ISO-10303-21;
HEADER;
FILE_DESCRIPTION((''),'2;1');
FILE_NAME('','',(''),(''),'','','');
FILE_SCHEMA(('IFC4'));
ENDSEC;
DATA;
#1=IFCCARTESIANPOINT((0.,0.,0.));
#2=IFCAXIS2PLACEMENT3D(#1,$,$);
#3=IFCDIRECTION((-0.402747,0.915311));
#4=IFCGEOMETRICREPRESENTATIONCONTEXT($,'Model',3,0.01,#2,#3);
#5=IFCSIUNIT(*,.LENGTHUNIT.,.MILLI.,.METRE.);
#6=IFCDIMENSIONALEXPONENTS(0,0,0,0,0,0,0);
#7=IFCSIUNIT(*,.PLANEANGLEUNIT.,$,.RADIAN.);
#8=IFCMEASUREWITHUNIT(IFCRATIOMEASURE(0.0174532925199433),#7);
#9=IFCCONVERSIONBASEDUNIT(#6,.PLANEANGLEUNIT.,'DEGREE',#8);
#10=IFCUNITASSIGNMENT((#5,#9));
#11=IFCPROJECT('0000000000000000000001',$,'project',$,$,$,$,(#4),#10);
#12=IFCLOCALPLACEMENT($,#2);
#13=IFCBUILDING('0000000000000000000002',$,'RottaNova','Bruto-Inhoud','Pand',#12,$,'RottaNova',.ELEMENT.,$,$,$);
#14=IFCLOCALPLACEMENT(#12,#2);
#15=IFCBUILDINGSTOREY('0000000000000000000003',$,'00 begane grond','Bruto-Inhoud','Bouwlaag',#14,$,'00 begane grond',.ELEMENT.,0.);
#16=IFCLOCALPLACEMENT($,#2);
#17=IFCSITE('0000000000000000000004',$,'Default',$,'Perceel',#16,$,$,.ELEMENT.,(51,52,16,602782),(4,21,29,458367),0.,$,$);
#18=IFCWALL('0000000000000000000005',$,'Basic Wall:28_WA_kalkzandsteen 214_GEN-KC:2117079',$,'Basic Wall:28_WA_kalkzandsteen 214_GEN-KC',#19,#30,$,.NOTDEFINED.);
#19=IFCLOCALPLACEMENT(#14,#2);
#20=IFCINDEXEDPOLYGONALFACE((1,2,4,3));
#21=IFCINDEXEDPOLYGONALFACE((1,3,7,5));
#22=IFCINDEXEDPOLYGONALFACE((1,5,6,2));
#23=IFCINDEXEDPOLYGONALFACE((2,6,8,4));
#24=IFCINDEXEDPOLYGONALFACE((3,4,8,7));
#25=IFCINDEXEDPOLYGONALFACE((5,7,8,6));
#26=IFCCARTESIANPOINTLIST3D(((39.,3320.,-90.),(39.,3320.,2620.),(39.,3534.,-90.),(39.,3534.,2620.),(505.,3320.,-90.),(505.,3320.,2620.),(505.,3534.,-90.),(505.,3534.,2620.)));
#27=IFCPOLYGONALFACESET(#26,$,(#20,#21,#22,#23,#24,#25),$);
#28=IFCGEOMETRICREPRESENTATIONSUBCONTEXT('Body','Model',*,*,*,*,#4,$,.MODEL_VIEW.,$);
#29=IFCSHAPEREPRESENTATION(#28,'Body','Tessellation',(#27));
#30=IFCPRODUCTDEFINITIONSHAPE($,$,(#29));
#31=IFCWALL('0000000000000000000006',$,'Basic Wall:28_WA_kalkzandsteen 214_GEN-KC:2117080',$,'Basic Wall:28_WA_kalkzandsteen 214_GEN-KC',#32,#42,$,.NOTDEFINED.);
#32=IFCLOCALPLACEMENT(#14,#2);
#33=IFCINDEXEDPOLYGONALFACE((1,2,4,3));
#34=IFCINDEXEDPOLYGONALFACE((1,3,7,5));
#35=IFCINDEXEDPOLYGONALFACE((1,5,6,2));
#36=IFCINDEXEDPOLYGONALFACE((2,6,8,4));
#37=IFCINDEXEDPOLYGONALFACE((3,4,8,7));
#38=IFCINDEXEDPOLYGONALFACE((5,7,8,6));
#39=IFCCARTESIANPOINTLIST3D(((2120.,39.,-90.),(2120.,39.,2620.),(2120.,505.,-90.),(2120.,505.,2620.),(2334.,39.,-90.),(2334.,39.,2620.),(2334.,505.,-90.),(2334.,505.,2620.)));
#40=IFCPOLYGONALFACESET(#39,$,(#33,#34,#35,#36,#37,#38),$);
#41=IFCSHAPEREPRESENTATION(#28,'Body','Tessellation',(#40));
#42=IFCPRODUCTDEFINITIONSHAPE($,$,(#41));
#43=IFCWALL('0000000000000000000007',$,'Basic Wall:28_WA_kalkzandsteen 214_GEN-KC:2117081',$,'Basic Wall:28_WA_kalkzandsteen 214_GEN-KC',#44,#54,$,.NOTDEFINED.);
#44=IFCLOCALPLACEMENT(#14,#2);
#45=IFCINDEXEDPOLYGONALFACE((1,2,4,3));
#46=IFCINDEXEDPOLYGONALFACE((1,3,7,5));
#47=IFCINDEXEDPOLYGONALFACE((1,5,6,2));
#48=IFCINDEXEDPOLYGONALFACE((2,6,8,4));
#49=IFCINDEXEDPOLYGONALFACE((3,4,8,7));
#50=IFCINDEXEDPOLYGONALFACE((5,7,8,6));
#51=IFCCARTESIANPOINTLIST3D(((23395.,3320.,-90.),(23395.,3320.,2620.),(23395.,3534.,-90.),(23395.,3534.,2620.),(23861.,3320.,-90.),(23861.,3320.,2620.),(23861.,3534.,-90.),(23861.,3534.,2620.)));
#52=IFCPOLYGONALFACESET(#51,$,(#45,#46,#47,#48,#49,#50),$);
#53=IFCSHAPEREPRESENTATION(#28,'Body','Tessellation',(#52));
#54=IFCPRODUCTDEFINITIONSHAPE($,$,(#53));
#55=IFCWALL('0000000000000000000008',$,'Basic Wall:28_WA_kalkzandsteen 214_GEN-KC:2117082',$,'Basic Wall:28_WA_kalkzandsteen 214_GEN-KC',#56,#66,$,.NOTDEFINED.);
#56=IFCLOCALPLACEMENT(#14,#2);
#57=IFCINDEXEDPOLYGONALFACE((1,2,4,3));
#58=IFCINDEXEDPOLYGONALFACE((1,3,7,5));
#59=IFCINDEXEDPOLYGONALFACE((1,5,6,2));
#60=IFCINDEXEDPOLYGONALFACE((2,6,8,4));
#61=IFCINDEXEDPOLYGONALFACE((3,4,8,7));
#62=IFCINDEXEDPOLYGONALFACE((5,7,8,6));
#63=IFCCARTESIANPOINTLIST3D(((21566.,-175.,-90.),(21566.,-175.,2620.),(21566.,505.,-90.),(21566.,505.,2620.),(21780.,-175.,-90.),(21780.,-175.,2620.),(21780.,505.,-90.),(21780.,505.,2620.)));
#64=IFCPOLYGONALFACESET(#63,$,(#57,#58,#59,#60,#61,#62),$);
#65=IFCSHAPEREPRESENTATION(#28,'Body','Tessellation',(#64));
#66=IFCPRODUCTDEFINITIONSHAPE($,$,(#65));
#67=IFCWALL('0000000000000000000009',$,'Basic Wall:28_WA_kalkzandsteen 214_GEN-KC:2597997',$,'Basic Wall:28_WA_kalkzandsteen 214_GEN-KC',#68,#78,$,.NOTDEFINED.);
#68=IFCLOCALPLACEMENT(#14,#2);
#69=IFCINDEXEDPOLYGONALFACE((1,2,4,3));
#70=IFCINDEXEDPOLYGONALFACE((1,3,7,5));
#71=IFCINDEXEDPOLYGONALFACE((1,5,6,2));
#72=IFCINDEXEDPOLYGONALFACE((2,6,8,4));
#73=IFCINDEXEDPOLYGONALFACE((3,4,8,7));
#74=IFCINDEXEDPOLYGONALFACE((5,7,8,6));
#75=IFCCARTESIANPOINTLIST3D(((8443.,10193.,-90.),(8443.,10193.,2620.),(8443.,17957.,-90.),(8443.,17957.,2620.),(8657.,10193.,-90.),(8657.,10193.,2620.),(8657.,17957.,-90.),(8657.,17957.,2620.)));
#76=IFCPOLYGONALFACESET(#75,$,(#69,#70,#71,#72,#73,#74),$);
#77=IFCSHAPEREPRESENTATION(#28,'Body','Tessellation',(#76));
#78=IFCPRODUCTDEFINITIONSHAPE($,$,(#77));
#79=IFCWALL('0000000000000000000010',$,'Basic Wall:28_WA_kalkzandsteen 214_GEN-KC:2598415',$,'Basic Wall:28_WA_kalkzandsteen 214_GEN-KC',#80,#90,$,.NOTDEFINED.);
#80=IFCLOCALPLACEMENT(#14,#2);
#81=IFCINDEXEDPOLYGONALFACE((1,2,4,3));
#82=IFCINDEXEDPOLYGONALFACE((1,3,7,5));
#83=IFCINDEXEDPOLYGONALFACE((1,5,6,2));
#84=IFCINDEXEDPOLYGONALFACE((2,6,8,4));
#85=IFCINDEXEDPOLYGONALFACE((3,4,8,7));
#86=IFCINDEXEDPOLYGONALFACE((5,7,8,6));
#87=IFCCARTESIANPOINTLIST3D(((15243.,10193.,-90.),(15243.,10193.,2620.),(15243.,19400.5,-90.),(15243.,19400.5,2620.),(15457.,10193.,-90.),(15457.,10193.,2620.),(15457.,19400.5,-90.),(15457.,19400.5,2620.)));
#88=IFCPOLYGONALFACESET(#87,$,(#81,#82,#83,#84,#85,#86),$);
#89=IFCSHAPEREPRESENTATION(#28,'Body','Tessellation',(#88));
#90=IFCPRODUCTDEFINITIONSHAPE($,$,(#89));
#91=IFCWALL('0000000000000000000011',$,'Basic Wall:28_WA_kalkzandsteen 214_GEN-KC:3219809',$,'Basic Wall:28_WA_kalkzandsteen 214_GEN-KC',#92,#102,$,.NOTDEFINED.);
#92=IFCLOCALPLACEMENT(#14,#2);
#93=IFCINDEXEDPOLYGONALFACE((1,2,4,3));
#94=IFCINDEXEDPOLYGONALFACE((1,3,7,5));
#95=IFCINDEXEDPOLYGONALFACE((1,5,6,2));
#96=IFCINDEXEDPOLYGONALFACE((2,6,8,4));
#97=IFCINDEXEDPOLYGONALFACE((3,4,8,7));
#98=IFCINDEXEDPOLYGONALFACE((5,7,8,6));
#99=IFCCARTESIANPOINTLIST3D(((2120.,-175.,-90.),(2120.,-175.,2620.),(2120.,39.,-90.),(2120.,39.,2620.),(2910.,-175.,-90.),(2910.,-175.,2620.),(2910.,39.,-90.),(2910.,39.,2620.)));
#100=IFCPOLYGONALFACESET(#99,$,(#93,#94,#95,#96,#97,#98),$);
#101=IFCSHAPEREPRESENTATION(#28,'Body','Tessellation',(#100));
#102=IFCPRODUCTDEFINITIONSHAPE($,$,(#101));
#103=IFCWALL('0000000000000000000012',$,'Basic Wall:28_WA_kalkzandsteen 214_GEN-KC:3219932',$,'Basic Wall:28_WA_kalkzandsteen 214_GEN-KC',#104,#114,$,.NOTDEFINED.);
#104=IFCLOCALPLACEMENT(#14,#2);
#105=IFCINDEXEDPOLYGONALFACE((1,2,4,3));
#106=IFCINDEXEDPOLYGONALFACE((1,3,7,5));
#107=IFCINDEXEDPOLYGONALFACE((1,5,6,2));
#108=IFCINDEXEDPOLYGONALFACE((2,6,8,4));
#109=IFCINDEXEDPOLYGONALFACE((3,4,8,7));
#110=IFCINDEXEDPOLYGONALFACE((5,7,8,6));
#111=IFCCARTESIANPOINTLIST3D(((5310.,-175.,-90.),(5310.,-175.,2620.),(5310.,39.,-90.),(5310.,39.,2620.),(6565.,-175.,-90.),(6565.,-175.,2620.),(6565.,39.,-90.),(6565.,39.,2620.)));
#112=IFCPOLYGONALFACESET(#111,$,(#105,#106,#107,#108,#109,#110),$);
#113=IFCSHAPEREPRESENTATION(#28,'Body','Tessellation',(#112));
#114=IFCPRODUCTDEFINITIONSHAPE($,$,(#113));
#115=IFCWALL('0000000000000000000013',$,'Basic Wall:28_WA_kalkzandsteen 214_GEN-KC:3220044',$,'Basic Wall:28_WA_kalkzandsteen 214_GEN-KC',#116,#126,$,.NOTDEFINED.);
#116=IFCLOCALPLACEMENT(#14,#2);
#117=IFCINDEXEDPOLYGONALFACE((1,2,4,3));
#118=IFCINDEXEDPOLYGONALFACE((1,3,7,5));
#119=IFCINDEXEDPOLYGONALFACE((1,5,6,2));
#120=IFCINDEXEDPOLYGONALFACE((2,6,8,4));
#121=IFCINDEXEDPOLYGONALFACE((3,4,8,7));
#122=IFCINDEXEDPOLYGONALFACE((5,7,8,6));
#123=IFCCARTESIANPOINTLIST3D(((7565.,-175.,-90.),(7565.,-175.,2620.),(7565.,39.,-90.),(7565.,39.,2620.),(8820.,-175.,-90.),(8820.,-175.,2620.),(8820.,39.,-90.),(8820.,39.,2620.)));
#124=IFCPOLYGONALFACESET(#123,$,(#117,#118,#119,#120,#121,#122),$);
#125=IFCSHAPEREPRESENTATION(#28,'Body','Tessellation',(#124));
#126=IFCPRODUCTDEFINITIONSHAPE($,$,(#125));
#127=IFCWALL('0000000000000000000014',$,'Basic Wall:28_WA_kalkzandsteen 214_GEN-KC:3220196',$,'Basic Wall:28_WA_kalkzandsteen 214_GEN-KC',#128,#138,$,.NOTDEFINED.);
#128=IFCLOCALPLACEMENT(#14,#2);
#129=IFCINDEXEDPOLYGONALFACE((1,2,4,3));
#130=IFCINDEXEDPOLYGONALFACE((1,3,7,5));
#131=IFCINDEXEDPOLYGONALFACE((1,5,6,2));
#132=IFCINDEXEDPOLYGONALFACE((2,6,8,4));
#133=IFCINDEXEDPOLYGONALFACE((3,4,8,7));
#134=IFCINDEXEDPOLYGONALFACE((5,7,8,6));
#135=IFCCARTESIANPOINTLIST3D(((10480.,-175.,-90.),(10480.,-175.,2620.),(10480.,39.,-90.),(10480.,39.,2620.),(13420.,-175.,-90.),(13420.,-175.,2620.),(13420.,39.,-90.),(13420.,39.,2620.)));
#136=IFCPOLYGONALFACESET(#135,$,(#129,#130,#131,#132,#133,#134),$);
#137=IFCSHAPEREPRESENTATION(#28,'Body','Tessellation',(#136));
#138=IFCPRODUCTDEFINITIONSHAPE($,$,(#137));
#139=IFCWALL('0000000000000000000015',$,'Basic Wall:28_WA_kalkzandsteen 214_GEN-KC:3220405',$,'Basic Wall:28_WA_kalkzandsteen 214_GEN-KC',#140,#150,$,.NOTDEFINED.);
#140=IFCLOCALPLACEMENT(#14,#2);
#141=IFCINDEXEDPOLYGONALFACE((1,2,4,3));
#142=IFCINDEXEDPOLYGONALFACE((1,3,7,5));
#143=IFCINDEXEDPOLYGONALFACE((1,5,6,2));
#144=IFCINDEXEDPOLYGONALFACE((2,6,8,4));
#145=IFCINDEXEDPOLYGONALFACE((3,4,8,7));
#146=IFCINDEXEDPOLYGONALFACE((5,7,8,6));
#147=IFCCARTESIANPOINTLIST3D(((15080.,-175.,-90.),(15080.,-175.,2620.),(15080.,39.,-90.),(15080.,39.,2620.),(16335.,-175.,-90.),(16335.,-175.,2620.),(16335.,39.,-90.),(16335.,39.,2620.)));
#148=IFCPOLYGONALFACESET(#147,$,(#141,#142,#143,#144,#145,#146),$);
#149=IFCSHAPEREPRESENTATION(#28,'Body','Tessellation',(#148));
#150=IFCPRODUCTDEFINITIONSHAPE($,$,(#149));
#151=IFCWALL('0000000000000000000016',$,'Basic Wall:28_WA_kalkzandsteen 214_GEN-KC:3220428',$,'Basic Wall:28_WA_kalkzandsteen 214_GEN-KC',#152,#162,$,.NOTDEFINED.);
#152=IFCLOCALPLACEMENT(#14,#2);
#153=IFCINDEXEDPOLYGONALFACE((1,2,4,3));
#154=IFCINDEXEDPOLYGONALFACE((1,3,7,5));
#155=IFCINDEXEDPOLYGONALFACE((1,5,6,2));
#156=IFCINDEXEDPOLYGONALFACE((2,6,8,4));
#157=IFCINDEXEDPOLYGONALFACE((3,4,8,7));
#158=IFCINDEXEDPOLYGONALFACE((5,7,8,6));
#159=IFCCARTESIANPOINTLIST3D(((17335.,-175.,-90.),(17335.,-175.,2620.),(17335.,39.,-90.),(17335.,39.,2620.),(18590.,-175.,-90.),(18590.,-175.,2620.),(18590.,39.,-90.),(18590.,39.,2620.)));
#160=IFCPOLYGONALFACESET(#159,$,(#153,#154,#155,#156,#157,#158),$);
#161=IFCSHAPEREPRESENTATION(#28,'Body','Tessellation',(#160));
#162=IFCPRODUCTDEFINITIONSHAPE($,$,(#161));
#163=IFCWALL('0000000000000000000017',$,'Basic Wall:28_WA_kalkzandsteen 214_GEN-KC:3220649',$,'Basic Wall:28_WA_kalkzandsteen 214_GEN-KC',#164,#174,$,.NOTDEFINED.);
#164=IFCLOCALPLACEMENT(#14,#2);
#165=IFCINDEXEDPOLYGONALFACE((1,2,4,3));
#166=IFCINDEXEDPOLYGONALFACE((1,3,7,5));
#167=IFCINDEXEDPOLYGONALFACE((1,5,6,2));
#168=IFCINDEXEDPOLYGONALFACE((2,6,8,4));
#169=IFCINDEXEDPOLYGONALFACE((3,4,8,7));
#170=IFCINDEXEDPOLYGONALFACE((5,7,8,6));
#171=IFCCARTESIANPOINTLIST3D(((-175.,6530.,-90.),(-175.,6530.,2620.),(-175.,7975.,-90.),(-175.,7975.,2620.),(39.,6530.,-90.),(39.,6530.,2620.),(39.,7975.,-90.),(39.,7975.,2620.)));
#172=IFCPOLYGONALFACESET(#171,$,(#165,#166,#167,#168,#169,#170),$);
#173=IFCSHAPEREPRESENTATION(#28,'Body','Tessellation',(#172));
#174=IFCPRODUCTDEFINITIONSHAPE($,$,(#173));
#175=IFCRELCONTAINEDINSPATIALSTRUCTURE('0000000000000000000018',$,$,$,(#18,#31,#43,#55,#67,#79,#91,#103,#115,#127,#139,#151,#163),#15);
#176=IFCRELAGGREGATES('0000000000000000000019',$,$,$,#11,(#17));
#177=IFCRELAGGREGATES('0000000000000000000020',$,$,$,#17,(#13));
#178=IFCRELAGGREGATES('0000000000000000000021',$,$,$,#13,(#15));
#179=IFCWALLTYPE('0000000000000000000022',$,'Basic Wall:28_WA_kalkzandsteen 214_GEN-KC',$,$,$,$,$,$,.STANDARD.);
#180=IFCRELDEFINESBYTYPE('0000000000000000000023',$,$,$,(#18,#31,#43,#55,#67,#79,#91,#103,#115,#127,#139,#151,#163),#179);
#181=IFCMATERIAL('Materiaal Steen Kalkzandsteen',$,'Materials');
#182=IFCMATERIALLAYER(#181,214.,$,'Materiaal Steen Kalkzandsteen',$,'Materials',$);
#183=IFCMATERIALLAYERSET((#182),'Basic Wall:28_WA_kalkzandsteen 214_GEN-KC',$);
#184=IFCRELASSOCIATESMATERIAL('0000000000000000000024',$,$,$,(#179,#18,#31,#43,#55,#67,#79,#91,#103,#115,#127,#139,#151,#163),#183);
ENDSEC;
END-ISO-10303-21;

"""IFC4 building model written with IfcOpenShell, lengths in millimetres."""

from ifc_helpers import new_model, entity, si_unit, converted_unit, direction, frame, frame_2d, origin, place, context, subcontext, project, spatial, rectangle, extrude, material, layer, layer_set, type_object, element, save


model = new_model("IFC4")

# Units and contexts
model_context = context("Model", 3, precision=0.01, world=origin(), true_north=direction((-0.402747, 0.915311)))
body_context = subcontext(model_context, "Body", "Model", "MODEL_VIEW")
ifc_project = project(units=[si_unit("LENGTHUNIT", "METRE", prefix="MILLI"), converted_unit("PLANEANGLEUNIT", "DEGREE", entity("IfcRatioMeasure", 0.0174532925199433), si_unit("PLANEANGLEUNIT", "RADIAN"), dimensions=[0, 0, 0, 0, 0, 0, 0])], contexts=[model_context])

# Site, building, storey
site_placement = place(None, origin())
site = spatial("IfcSite", under=ifc_project, at=site_placement, Name="Default", ObjectType="Perceel", CompositionType="ELEMENT", RefLatitude=(51, 52, 16, 602782), RefLongitude=(4, 21, 29, 458367), RefElevation=0.0)
building_placement = place(None, origin())
building = spatial("IfcBuilding", under=site, at=building_placement, Name="RottaNova", Description="Bruto-Inhoud", ObjectType="Pand", LongName="RottaNova", CompositionType="ELEMENT")
storey_placement = place(building_placement, origin())
storey = spatial("IfcBuildingStorey", under=building, at=storey_placement, Name="00 begane grond", Description="Bruto-Inhoud", ObjectType="Bouwlaag", LongName="00 begane grond", CompositionType="ELEMENT", Elevation=0.0)

# Walls
ifc_material_1 = material(Name="Materiaal Steen Kalkzandsteen", Category="Materials")
ifc_layer_1 = layer(ifc_material_1, 214.0, Name="Materiaal Steen Kalkzandsteen", Category="Materials")
ifc_layer_set_1 = layer_set([ifc_layer_1], Name="Basic Wall:28_WA_kalkzandsteen 214_GEN-KC")
wall_type = type_object("IfcWallType", Name="Basic Wall:28_WA_kalkzandsteen 214_GEN-KC", PredefinedType="STANDARD", material=ifc_layer_set_1)
wall_1_placement = place(storey_placement, frame((39.0, 3427.0, -90.0)))
element("IfcWall", 1, at=wall_1_placement, inside=storey, type_object=wall_type, material=ifc_layer_set_1, Name="Basic Wall:28_WA_kalkzandsteen 214_GEN-KC:2117079", ObjectType="Basic Wall:28_WA_kalkzandsteen 214_GEN-KC", PredefinedType="NOTDEFINED", context=body_context, shape_type="SweptSolid", body=[
    extrude(rectangle(XDim=466.0, YDim=214.0, at=frame_2d((233.0, 0.0), x_axis=(-1.0, 0.0))), origin(), (0.0, 0.0, 1.0), 2710.0),
])
wall_2_placement = place(storey_placement, frame((2227.0, 505.0, -90.0), z_axis=(0.0, 0.0, 1.0), x_axis=(0.0, -1.0, 0.0)))
element("IfcWall", 2, at=wall_2_placement, inside=storey, type_object=wall_type, material=ifc_layer_set_1, Name="Basic Wall:28_WA_kalkzandsteen 214_GEN-KC:2117080", ObjectType="Basic Wall:28_WA_kalkzandsteen 214_GEN-KC", PredefinedType="NOTDEFINED", context=body_context, shape_type="SweptSolid", body=[
    extrude(rectangle(XDim=466.0, YDim=214.0, at=frame_2d((233.0, 0.0), x_axis=(-1.0, 0.0))), origin(), (0.0, 0.0, 1.0), 2710.0),
])
wall_3_placement = place(storey_placement, frame((23861.0, 3427.0, -90.0), z_axis=(0.0, 0.0, 1.0), x_axis=(-1.0, 0.0, 0.0)))
element("IfcWall", 3, at=wall_3_placement, inside=storey, type_object=wall_type, material=ifc_layer_set_1, Name="Basic Wall:28_WA_kalkzandsteen 214_GEN-KC:2117081", ObjectType="Basic Wall:28_WA_kalkzandsteen 214_GEN-KC", PredefinedType="NOTDEFINED", context=body_context, shape_type="SweptSolid", body=[
    extrude(rectangle(XDim=466.0, YDim=214.0, at=frame_2d((233.0, 0.0), x_axis=(-1.0, 0.0))), origin(), (0.0, 0.0, 1.0), 2710.0),
])
wall_4_placement = place(storey_placement, frame((21673.0, -175.0, -90.0), z_axis=(0.0, 0.0, 1.0), x_axis=(0.0, 1.0, 0.0)))
element("IfcWall", 4, at=wall_4_placement, inside=storey, type_object=wall_type, material=ifc_layer_set_1, Name="Basic Wall:28_WA_kalkzandsteen 214_GEN-KC:2117082", ObjectType="Basic Wall:28_WA_kalkzandsteen 214_GEN-KC", PredefinedType="NOTDEFINED", context=body_context, shape_type="SweptSolid", body=[
    extrude(rectangle(XDim=680.0, YDim=214.0, at=frame_2d((340.0, 0.0), x_axis=(-1.0, 0.0))), origin(), (0.0, 0.0, 1.0), 2710.0),
])
wall_5_placement = place(storey_placement, frame((8550.0, 10193.0, -90.0), z_axis=(0.0, 0.0, 1.0), x_axis=(0.0, 1.0, 0.0)))
element("IfcWall", 5, at=wall_5_placement, inside=storey, type_object=wall_type, material=ifc_layer_set_1, Name="Basic Wall:28_WA_kalkzandsteen 214_GEN-KC:2597997", ObjectType="Basic Wall:28_WA_kalkzandsteen 214_GEN-KC", PredefinedType="NOTDEFINED", context=body_context, shape_type="SweptSolid", body=[
    extrude(rectangle(XDim=7764.0, YDim=214.0, at=frame_2d((3882.0, 0.0), x_axis=(1.0, 0.0))), origin(), (0.0, 0.0, 1.0), 2710.0),
])
wall_6_placement = place(storey_placement, frame((15350.0, 10193.0, -90.0), z_axis=(0.0, 0.0, 1.0), x_axis=(0.0, 1.0, 0.0)))
element("IfcWall", 6, at=wall_6_placement, inside=storey, type_object=wall_type, material=ifc_layer_set_1, Name="Basic Wall:28_WA_kalkzandsteen 214_GEN-KC:2598415", ObjectType="Basic Wall:28_WA_kalkzandsteen 214_GEN-KC", PredefinedType="NOTDEFINED", context=body_context, shape_type="SweptSolid", body=[
    extrude(rectangle(XDim=9207.5, YDim=214.0, at=frame_2d((4603.8, 0.0), x_axis=(1.0, 0.0))), origin(), (0.0, 0.0, 1.0), 2710.0),
])
wall_7_placement = place(storey_placement, frame((2910.0, -68.0, -90.0), z_axis=(0.0, 0.0, 1.0), x_axis=(-1.0, 0.0, 0.0)))
element("IfcWall", 7, at=wall_7_placement, inside=storey, type_object=wall_type, material=ifc_layer_set_1, Name="Basic Wall:28_WA_kalkzandsteen 214_GEN-KC:3219809", ObjectType="Basic Wall:28_WA_kalkzandsteen 214_GEN-KC", PredefinedType="NOTDEFINED", context=body_context, shape_type="SweptSolid", body=[
    extrude(rectangle(XDim=790.0, YDim=214.0, at=frame_2d((395.0, 0.0), x_axis=(-1.0, 0.0))), origin(), (0.0, 0.0, 1.0), 2710.0),
])
wall_8_placement = place(storey_placement, frame((6565.0, -68.0, -90.0), z_axis=(0.0, 0.0, 1.0), x_axis=(-1.0, 0.0, 0.0)))
element("IfcWall", 8, at=wall_8_placement, inside=storey, type_object=wall_type, material=ifc_layer_set_1, Name="Basic Wall:28_WA_kalkzandsteen 214_GEN-KC:3219932", ObjectType="Basic Wall:28_WA_kalkzandsteen 214_GEN-KC", PredefinedType="NOTDEFINED", context=body_context, shape_type="SweptSolid", body=[
    extrude(rectangle(XDim=1255.0, YDim=214.0, at=frame_2d((627.5, 0.0), x_axis=(-1.0, 0.0))), origin(), (0.0, 0.0, 1.0), 2710.0),
])
wall_9_placement = place(storey_placement, frame((8820.0, -68.0, -90.0), z_axis=(0.0, 0.0, 1.0), x_axis=(-1.0, 0.0, 0.0)))
element("IfcWall", 9, at=wall_9_placement, inside=storey, type_object=wall_type, material=ifc_layer_set_1, Name="Basic Wall:28_WA_kalkzandsteen 214_GEN-KC:3220044", ObjectType="Basic Wall:28_WA_kalkzandsteen 214_GEN-KC", PredefinedType="NOTDEFINED", context=body_context, shape_type="SweptSolid", body=[
    extrude(rectangle(XDim=1255.0, YDim=214.0, at=frame_2d((627.5, 0.0), x_axis=(-1.0, 0.0))), origin(), (0.0, 0.0, 1.0), 2710.0),
])
wall_10_placement = place(storey_placement, frame((13420.0, -68.0, -90.0), z_axis=(0.0, 0.0, 1.0), x_axis=(-1.0, 0.0, 0.0)))
element("IfcWall", 10, at=wall_10_placement, inside=storey, type_object=wall_type, material=ifc_layer_set_1, Name="Basic Wall:28_WA_kalkzandsteen 214_GEN-KC:3220196", ObjectType="Basic Wall:28_WA_kalkzandsteen 214_GEN-KC", PredefinedType="NOTDEFINED", context=body_context, shape_type="SweptSolid", body=[
    extrude(rectangle(XDim=2940.0, YDim=214.0, at=frame_2d((1470.0, 0.0), x_axis=(-1.0, 0.0))), origin(), (0.0, 0.0, 1.0), 2710.0),
])
wall_11_placement = place(storey_placement, frame((16335.0, -68.0, -90.0), z_axis=(0.0, 0.0, 1.0), x_axis=(-1.0, 0.0, 0.0)))
element("IfcWall", 11, at=wall_11_placement, inside=storey, type_object=wall_type, material=ifc_layer_set_1, Name="Basic Wall:28_WA_kalkzandsteen 214_GEN-KC:3220405", ObjectType="Basic Wall:28_WA_kalkzandsteen 214_GEN-KC", PredefinedType="NOTDEFINED", context=body_context, shape_type="SweptSolid", body=[
    extrude(rectangle(XDim=1255.0, YDim=214.0, at=frame_2d((627.5, 0.0), x_axis=(-1.0, 0.0))), origin(), (0.0, 0.0, 1.0), 2710.0),
])
wall_12_placement = place(storey_placement, frame((18590.0, -68.0, -90.0), z_axis=(0.0, 0.0, 1.0), x_axis=(-1.0, 0.0, 0.0)))
element("IfcWall", 12, at=wall_12_placement, inside=storey, type_object=wall_type, material=ifc_layer_set_1, Name="Basic Wall:28_WA_kalkzandsteen 214_GEN-KC:3220428", ObjectType="Basic Wall:28_WA_kalkzandsteen 214_GEN-KC", PredefinedType="NOTDEFINED", context=body_context, shape_type="SweptSolid", body=[
    extrude(rectangle(XDim=1255.0, YDim=214.0, at=frame_2d((627.5, 0.0), x_axis=(-1.0, 0.0))), origin(), (0.0, 0.0, 1.0), 2710.0),
])
wall_13_placement = place(storey_placement, frame((-68.0, 6530.0, -90.0), z_axis=(0.0, 0.0, 1.0), x_axis=(0.0, 1.0, 0.0)))
element("IfcWall", 13, at=wall_13_placement, inside=storey, type_object=wall_type, material=ifc_layer_set_1, Name="Basic Wall:28_WA_kalkzandsteen 214_GEN-KC:3220649", ObjectType="Basic Wall:28_WA_kalkzandsteen 214_GEN-KC", PredefinedType="NOTDEFINED", context=body_context, shape_type="SweptSolid", body=[
    extrude(rectangle(XDim=1445.0, YDim=214.0, at=frame_2d((722.5, 0.0), x_axis=(-1.0, 0.0))), origin(), (0.0, 0.0, 1.0), 2710.0),
])

save(model, "model.ifc")
